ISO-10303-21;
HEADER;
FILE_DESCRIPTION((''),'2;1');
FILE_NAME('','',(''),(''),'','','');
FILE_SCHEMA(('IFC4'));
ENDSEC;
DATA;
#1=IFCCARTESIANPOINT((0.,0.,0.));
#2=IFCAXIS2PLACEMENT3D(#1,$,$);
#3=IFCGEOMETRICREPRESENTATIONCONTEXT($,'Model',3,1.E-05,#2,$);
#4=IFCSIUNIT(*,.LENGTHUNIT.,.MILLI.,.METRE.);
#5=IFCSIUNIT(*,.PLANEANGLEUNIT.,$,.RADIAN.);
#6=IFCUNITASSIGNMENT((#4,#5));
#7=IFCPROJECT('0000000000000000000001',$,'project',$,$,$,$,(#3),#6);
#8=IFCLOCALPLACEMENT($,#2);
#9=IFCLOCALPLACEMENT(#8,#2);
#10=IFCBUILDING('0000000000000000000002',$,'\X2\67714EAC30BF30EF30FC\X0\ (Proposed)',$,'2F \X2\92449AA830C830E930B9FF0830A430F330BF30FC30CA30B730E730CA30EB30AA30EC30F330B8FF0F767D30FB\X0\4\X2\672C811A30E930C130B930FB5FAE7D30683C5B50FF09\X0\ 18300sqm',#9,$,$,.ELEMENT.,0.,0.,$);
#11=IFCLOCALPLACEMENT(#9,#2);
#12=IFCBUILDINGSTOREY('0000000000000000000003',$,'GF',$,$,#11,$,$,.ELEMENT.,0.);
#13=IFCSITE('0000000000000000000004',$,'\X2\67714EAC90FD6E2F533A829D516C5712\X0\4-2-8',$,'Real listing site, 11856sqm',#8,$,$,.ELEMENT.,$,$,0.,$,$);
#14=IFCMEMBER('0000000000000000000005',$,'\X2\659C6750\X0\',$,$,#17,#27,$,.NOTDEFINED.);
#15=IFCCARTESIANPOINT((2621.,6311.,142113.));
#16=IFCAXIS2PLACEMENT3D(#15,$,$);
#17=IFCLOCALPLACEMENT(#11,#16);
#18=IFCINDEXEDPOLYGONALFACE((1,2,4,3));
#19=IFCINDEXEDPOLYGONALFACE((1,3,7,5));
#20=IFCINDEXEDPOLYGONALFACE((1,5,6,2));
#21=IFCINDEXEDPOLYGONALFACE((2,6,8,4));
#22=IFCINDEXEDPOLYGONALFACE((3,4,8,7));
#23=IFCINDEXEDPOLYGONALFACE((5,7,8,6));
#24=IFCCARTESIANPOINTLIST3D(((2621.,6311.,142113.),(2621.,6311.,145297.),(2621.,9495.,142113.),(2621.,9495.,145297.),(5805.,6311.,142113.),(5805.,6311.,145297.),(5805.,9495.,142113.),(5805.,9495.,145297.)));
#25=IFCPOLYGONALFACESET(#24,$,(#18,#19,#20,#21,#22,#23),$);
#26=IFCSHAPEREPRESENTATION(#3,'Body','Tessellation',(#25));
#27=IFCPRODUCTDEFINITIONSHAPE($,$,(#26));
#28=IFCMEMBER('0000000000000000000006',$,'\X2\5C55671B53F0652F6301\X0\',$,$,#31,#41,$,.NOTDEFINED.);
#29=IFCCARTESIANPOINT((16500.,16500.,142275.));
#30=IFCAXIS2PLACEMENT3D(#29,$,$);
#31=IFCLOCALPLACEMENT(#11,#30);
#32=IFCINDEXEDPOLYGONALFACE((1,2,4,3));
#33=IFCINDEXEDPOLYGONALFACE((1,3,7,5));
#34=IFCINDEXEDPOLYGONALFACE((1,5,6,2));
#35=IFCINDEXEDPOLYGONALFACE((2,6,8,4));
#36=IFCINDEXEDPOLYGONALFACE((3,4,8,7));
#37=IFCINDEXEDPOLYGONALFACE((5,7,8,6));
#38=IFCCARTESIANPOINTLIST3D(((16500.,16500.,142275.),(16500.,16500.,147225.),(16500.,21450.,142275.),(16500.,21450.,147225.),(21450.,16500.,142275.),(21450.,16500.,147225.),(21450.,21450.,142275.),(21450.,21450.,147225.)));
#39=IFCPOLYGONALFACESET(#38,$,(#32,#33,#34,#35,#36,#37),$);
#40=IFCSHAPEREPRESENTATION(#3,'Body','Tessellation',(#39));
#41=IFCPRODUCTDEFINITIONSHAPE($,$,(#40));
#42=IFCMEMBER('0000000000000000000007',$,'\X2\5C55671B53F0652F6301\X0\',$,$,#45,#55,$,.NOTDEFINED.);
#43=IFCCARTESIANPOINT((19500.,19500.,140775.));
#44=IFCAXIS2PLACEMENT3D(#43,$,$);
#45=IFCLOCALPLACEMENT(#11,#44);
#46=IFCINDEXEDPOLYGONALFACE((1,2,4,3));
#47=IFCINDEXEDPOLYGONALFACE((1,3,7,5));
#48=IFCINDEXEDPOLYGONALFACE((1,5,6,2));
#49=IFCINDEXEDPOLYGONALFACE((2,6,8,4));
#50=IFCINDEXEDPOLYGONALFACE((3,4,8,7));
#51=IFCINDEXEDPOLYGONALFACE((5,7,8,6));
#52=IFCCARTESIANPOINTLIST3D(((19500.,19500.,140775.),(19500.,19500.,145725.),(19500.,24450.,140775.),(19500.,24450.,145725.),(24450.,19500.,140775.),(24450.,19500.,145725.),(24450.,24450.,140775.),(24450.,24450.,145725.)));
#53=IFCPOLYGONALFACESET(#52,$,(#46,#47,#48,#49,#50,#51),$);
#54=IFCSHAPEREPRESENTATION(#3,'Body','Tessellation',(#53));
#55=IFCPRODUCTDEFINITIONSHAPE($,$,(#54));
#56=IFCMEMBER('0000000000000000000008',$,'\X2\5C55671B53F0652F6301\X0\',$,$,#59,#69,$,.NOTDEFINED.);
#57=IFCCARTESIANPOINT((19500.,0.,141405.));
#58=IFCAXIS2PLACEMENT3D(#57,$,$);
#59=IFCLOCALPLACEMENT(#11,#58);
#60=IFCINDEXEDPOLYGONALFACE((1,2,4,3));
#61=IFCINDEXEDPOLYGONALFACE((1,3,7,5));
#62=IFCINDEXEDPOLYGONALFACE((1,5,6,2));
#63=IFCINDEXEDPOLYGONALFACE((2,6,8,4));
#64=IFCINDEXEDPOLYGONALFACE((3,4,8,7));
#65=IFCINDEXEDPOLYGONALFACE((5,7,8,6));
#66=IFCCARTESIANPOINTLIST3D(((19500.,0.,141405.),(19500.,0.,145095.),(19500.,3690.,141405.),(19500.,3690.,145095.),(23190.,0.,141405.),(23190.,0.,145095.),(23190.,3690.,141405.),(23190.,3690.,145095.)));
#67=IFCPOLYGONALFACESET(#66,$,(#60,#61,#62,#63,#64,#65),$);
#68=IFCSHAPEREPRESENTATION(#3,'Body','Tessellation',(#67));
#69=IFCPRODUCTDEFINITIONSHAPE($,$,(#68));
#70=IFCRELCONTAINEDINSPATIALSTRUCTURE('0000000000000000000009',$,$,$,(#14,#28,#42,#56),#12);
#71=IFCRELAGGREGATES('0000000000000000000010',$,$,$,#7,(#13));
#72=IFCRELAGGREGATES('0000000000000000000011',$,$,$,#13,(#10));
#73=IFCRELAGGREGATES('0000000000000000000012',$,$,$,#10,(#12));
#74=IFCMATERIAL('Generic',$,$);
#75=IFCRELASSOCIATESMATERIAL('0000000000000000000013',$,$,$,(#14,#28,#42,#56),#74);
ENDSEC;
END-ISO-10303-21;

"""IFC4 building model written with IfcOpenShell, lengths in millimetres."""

from ifc_helpers import new_model, si_unit, frame, frame_2d, origin, place, context, project, spatial, rectangle, extrude, material, element, save


model = new_model("IFC4")

# Units and contexts
model_context = context("Model", 3, precision=1e-05, world=origin())
ifc_project = project(units=[si_unit("LENGTHUNIT", "METRE", prefix="MILLI"), si_unit("PLANEANGLEUNIT", "RADIAN")], contexts=[model_context])

# Site, building, storey
site_placement = place(None, origin())
site = spatial("IfcSite", under=ifc_project, at=site_placement, Name="東京都港区芝公園4-2-8", ObjectType="Real listing site, 11856sqm", CompositionType="ELEMENT", RefElevation=0.0)
building_placement = place(site_placement, origin())
building = spatial("IfcBuilding", under=site, at=building_placement, Name="東京タワー (Proposed)", ObjectType="2F 鉄骨トラス（インターナショナルオレンジ／白・4本脚ラチス・微細格子） 18300sqm", CompositionType="ELEMENT", ElevationOfRefHeight=0.0, ElevationOfTerrain=0.0)
storey_placement = place(building_placement, origin())
storey = spatial("IfcBuildingStorey", under=building, at=storey_placement, Name="GF", CompositionType="ELEMENT", Elevation=0.0)

# Members
ifc_material = material(Name="Generic")
member_1_placement = place(storey_placement, frame((2621.0, 6311.0, 142113.0)))
element("IfcMember", 1, at=member_1_placement, inside=storey, material=ifc_material, Name="斜材", PredefinedType="NOTDEFINED", context=model_context, shape_type="SweptSolid", body=[
    extrude(rectangle(XDim=3184.0, YDim=3184.0, at=frame_2d((1592.0, 1592.0))), frame((2621.0, 6311.0, 142113.0)), (0.0, 0.0, 1.0), 3184.0),
])
member_2_placement = place(storey_placement, frame((16500.0, 16500.0, 142275.0)))
element("IfcMember", 2, at=member_2_placement, inside=storey, material=ifc_material, Name="展望台支持", PredefinedType="NOTDEFINED", context=model_context, shape_type="SweptSolid", body=[
    extrude(rectangle(XDim=4950.0, YDim=4950.0, at=frame_2d((2475.0, 2475.0))), frame((16500.0, 16500.0, 142275.0)), (0.0, 0.0, 1.0), 4950.0),
])
member_3_placement = place(storey_placement, frame((19500.0, 19500.0, 140775.0)))
element("IfcMember", 3, at=member_3_placement, inside=storey, material=ifc_material, Name="展望台支持", PredefinedType="NOTDEFINED", context=model_context, shape_type="SweptSolid", body=[
    extrude(rectangle(XDim=4950.0, YDim=4950.0, at=frame_2d((2475.0, 2475.0))), frame((19500.0, 19500.0, 140775.0)), (0.0, 0.0, 1.0), 4950.0),
])
for number, where, name in (
    (4, (19500.0, 0.0, 141405.0), "展望台支持"),
):
    element("IfcMember", number, at=place(storey_placement, frame(where)), inside=storey, material=ifc_material, Name=name, PredefinedType="NOTDEFINED", context=model_context, shape_type="SweptSolid", body=[
        extrude(rectangle(XDim=3690.0, YDim=3690.0, at=frame_2d((1845.0, 1845.0))), frame((19500.0, 0.0, 141405.0)), (0.0, 0.0, 1.0), 3690.0),
    ])

save(model, "model.ifc")
